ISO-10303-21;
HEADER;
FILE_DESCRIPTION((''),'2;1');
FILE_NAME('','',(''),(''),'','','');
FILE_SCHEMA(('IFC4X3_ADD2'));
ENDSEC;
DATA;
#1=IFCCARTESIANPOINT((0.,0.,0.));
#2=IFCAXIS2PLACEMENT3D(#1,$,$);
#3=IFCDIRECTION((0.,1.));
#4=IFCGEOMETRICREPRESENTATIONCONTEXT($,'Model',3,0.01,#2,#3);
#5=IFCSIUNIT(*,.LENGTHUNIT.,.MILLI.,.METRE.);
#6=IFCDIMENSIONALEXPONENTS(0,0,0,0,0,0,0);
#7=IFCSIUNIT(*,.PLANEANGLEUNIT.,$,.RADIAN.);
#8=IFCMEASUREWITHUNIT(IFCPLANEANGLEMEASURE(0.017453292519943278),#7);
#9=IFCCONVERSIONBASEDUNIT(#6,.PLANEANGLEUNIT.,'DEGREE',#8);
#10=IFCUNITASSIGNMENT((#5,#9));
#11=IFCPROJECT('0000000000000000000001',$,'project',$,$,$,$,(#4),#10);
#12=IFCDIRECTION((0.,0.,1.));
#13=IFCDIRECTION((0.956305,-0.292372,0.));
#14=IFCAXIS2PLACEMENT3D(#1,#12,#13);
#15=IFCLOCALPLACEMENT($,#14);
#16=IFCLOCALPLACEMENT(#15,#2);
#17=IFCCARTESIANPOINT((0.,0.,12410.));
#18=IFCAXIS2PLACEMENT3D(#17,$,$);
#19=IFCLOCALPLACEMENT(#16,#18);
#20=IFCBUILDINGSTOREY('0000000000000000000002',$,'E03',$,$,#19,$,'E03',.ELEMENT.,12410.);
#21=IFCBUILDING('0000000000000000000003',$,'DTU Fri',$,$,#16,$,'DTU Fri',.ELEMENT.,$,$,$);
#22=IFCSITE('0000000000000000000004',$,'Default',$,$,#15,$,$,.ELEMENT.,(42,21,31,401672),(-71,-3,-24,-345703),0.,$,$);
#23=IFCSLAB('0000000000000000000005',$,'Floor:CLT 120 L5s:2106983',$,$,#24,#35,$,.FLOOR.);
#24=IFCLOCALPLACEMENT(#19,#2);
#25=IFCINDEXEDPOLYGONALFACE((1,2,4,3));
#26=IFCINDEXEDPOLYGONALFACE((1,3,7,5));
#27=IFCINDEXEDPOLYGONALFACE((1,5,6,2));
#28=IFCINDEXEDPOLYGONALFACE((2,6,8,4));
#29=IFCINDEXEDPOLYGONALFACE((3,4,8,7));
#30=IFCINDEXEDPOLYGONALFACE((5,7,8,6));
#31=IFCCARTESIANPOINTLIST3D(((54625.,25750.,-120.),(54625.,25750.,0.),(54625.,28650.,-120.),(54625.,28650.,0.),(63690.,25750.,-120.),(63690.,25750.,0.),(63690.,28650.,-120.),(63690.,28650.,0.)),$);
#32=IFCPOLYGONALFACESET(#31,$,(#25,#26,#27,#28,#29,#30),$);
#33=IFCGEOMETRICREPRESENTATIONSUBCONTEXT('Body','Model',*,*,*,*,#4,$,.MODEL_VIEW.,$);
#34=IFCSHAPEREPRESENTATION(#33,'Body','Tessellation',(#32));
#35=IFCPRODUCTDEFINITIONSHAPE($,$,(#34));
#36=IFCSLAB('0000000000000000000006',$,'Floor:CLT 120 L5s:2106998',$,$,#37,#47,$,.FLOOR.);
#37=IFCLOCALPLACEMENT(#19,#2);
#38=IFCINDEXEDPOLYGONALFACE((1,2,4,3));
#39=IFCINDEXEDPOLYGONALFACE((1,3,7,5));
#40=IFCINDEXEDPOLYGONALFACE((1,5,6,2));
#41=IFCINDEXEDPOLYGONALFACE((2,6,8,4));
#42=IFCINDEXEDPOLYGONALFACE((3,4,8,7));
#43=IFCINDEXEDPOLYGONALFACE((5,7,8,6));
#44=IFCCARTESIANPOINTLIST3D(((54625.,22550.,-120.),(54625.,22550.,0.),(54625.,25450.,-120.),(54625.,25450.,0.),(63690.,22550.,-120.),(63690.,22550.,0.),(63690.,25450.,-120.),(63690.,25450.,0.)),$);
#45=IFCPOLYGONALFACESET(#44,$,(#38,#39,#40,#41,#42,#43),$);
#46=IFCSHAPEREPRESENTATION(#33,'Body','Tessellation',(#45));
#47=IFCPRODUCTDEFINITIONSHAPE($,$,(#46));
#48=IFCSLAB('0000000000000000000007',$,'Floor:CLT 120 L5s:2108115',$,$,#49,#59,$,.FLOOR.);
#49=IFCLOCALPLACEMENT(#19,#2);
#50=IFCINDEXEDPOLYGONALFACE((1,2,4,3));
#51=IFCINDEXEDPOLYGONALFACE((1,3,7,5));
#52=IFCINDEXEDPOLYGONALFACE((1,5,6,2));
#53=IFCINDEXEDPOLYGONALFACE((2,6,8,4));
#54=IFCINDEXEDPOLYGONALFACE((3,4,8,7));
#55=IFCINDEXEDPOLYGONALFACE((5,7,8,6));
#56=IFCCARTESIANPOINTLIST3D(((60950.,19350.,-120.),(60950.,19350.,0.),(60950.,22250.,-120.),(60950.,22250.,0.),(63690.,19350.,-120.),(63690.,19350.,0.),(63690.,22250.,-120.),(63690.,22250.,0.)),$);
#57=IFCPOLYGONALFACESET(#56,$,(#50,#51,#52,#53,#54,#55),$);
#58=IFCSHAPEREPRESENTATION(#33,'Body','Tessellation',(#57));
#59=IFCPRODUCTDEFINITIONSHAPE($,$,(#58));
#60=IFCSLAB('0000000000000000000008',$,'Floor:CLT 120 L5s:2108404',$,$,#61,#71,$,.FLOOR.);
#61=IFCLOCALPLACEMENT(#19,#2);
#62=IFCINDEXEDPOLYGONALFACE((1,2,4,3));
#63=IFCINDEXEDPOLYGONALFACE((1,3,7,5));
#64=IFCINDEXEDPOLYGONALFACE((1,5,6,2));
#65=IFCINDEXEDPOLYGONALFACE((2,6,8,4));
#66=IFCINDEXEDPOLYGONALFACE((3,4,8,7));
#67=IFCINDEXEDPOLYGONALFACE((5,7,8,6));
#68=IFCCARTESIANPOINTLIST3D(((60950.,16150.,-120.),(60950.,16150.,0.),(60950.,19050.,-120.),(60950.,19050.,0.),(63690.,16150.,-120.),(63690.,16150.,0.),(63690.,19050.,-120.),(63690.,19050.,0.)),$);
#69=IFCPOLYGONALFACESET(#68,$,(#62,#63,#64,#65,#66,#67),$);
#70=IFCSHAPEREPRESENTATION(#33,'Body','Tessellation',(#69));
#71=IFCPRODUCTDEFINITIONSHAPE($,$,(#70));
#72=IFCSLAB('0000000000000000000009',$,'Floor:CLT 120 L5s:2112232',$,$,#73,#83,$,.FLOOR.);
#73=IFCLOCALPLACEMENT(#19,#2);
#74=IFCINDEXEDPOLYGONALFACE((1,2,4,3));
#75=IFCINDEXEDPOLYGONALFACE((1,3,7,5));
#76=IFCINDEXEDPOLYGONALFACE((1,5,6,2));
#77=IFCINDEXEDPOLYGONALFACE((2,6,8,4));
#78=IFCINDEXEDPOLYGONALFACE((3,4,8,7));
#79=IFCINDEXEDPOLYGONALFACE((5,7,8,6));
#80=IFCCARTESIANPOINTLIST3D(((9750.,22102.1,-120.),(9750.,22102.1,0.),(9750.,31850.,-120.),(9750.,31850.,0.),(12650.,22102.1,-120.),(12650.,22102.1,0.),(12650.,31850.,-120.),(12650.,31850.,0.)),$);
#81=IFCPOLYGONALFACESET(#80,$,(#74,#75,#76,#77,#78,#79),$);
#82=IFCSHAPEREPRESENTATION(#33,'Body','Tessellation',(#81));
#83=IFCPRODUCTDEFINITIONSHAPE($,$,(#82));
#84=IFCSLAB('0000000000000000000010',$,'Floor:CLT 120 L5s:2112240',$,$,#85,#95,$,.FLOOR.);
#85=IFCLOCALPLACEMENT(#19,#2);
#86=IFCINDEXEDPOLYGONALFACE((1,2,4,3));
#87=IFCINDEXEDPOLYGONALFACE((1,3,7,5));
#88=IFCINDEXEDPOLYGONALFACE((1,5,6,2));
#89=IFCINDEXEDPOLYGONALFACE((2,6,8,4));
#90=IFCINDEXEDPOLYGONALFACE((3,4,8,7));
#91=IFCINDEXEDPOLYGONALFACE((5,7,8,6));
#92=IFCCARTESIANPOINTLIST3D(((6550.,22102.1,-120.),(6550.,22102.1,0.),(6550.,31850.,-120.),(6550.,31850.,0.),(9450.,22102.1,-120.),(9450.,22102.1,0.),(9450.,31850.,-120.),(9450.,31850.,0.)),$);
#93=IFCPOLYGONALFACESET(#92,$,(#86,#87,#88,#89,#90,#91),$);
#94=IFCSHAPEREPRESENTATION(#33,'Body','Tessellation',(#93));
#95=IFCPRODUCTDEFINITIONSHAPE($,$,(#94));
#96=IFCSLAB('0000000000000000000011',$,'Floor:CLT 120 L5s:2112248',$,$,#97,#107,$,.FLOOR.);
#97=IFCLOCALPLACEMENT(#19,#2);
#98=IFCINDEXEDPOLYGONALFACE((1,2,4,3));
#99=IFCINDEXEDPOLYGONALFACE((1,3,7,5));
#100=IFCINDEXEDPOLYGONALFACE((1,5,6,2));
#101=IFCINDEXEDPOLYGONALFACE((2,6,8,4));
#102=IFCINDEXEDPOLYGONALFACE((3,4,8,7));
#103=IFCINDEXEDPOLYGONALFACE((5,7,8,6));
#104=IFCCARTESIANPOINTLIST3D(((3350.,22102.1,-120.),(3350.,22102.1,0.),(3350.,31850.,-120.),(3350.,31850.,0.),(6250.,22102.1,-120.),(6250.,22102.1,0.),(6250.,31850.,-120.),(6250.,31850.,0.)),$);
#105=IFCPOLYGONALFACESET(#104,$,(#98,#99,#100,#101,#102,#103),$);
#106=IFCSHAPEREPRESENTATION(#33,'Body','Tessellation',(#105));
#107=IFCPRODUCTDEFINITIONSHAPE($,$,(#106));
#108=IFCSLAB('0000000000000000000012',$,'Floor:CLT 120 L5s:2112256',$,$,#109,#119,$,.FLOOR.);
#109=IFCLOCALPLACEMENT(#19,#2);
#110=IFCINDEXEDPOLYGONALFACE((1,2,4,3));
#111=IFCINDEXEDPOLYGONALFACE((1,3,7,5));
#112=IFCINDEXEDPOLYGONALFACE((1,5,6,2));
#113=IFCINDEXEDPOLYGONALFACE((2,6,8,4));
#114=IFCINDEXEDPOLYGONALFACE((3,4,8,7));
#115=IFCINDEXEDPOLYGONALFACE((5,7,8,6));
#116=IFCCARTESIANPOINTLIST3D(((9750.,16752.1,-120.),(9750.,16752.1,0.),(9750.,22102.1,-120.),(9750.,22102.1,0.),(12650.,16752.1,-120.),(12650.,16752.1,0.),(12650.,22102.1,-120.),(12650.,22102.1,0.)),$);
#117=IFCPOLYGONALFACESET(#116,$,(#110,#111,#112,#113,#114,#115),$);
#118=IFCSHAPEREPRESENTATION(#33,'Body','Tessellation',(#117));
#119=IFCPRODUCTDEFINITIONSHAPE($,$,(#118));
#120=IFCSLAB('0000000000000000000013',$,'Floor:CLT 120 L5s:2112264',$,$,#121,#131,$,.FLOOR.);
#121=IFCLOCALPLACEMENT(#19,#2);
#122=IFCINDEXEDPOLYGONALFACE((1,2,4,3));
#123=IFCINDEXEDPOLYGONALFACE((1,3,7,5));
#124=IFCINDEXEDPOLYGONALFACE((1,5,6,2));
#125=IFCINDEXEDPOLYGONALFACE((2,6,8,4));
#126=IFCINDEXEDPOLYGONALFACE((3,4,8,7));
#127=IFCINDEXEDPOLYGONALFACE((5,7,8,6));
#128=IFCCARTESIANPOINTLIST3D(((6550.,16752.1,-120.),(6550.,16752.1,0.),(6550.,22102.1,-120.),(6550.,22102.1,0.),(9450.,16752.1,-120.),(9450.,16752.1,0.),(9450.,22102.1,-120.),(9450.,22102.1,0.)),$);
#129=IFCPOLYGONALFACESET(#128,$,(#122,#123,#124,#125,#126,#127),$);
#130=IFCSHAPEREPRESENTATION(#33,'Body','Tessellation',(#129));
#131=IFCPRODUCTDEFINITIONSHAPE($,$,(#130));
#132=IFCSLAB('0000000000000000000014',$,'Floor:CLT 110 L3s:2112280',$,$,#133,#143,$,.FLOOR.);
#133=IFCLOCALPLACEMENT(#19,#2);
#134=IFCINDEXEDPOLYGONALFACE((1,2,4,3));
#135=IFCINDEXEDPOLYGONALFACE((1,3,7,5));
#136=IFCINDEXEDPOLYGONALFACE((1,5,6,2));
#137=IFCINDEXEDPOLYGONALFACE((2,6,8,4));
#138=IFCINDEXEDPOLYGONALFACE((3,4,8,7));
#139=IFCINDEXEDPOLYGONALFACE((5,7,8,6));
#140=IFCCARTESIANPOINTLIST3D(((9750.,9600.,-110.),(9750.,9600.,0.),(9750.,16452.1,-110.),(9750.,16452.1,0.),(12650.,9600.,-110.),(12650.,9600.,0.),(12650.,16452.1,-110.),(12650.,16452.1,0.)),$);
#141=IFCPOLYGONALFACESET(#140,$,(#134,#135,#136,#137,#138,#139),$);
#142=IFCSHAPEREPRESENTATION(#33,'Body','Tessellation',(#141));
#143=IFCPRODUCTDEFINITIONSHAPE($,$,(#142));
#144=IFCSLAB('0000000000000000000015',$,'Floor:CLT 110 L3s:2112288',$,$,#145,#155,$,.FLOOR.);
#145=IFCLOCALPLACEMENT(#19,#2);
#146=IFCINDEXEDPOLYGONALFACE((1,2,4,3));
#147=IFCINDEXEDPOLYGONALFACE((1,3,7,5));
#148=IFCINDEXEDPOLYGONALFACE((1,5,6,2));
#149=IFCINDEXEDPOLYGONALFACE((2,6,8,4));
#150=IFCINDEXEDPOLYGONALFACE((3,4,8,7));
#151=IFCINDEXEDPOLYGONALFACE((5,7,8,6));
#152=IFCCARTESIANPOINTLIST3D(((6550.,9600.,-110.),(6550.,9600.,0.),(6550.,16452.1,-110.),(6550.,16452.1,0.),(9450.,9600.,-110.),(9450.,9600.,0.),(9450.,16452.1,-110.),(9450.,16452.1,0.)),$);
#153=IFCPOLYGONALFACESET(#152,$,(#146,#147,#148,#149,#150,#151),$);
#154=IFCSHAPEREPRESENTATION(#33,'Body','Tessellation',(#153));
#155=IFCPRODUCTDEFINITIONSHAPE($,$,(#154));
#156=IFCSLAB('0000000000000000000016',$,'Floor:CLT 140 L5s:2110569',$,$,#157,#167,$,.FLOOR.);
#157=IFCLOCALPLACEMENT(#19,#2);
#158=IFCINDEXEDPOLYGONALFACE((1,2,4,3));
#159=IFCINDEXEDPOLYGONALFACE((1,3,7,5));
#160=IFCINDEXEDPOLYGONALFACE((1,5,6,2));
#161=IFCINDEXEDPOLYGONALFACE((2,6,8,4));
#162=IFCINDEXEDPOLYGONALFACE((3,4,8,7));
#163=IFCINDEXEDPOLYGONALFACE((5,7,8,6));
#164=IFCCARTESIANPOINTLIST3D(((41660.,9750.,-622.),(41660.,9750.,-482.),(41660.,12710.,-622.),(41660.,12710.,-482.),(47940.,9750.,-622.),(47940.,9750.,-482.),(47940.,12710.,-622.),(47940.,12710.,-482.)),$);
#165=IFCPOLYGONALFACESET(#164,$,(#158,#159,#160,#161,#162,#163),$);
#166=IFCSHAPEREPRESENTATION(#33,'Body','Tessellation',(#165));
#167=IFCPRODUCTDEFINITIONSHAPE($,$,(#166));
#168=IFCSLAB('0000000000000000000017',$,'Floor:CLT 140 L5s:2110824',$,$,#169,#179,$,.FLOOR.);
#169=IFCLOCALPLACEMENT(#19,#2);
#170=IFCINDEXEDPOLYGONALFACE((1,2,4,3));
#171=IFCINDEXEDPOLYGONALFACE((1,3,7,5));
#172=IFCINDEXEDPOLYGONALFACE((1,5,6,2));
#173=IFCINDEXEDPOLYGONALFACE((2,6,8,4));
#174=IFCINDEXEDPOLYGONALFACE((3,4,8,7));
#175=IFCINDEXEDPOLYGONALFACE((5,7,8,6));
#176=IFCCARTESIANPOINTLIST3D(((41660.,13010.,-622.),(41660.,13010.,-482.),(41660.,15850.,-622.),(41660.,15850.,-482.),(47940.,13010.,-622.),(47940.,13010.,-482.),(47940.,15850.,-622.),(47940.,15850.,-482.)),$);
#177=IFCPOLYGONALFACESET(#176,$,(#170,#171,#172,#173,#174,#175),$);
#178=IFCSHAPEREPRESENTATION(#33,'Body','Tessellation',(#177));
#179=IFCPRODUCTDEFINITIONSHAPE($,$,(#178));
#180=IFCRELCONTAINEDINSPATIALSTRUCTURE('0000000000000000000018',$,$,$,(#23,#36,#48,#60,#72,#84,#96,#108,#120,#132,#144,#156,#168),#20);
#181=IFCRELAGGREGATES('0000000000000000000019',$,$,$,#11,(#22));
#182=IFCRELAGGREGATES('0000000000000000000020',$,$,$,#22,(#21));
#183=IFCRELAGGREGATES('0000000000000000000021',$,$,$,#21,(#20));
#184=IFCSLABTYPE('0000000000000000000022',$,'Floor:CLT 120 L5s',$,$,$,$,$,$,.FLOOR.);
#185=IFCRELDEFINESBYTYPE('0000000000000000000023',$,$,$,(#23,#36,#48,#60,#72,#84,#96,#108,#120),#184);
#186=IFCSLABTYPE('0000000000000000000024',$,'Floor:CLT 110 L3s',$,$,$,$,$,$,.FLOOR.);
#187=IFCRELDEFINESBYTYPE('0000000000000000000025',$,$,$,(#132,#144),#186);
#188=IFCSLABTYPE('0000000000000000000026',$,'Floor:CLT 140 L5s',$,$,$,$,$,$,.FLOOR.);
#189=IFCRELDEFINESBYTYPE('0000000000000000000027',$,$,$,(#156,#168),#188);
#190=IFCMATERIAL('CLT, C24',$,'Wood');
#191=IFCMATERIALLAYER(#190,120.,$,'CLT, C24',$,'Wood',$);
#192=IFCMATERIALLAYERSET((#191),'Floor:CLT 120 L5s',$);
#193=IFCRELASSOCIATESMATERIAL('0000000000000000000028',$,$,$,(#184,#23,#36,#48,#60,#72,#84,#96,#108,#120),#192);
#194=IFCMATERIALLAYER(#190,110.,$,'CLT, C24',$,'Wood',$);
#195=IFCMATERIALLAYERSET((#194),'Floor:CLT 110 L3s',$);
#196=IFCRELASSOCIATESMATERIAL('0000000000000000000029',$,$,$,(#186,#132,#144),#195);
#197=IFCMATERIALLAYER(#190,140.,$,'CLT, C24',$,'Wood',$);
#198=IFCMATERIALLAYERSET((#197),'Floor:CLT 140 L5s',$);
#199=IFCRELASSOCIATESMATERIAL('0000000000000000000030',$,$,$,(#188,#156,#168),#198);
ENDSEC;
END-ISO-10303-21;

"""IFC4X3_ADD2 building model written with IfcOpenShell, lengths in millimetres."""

from ifc_helpers import new_model, entity, si_unit, converted_unit, direction, frame, frame_2d, origin, origin_2d_with_axis, place, context, subcontext, project, spatial, rectangle, extrude, material, layer, layer_set, layer_usage, type_object, element, save


model = new_model("IFC4X3_ADD2")

# Units and contexts
model_context = context("Model", 3, precision=0.01, world=origin(), true_north=direction((0.0, 1.0)))
body_context = subcontext(model_context, "Body", "Model", "MODEL_VIEW")
ifc_project = project(units=[si_unit("LENGTHUNIT", "METRE", prefix="MILLI"), converted_unit("PLANEANGLEUNIT", "DEGREE", entity("IfcPlaneAngleMeasure", 0.017453292519943278), si_unit("PLANEANGLEUNIT", "RADIAN"), dimensions=[0, 0, 0, 0, 0, 0, 0])], contexts=[model_context])

# Site, building, storey
site_placement = place(None, frame((0.0, 0.0, 0.0), z_axis=(0.0, 0.0, 1.0), x_axis=(0.956305, -0.292372, 0.0)))
site = spatial("IfcSite", under=ifc_project, at=site_placement, Name="Default", CompositionType="ELEMENT", RefLatitude=(42, 21, 31, 401672), RefLongitude=(-71, -3, -24, -345703), RefElevation=0.0)
building_placement = place(site_placement, origin())
building = spatial("IfcBuilding", under=site, at=building_placement, Name="DTU Fri", LongName="DTU Fri", CompositionType="ELEMENT")
storey_placement = place(building_placement, frame((0.0, 0.0, 12410.0)))
storey = spatial("IfcBuildingStorey", under=building, at=storey_placement, Name="E03", LongName="E03", CompositionType="ELEMENT", Elevation=12410.0)

# Slabs
ifc_material = material(Name="CLT, C24", Category="Wood")
ifc_layer_1 = layer(ifc_material, 120.0, Name="CLT, C24", Category="Wood")
ifc_layer_set_1 = layer_set([ifc_layer_1], Name="Floor:CLT 120 L5s")
ifc_layer_usage_1 = layer_usage(ifc_layer_set_1, "AXIS3", "POSITIVE", 0.0)
slab_type_1 = type_object("IfcSlabType", Name="Floor:CLT 120 L5s", PredefinedType="FLOOR", material=ifc_layer_set_1)
slab_1_placement = place(storey_placement, origin())
element("IfcSlab", 1, at=slab_1_placement, inside=storey, type_object=slab_type_1, material=ifc_layer_usage_1, Name="Floor:CLT 120 L5s:2106983", PredefinedType="FLOOR", context=body_context, shape_type="SweptSolid", body=[
    extrude(rectangle(XDim=2900.0, YDim=9065.0, at=frame_2d((0.0, 0.0), x_axis=(1.0, 0.0))), frame((59157.5, 27200.0, 0.0), z_axis=(0.0, 0.0, -1.0), x_axis=(0.0, 1.0, 0.0)), (0.0, 0.0, 1.0), 120.0),
])
ifc_layer_usage_2 = layer_usage(ifc_layer_set_1, "AXIS3", "POSITIVE", 0.0)
slab_2_placement = place(storey_placement, origin())
element("IfcSlab", 2, at=slab_2_placement, inside=storey, type_object=slab_type_1, material=ifc_layer_usage_2, Name="Floor:CLT 120 L5s:2106998", PredefinedType="FLOOR", context=body_context, shape_type="SweptSolid", body=[
    extrude(rectangle(XDim=2900.0, YDim=9065.0, at=frame_2d((0.0, 0.0), x_axis=(1.0, 0.0))), frame((59157.5, 24000.0, 0.0), z_axis=(0.0, 0.0, -1.0), x_axis=(0.0, 1.0, 0.0)), (0.0, 0.0, 1.0), 120.0),
])
ifc_layer_usage_3 = layer_usage(ifc_layer_set_1, "AXIS3", "POSITIVE", 0.0)
slab_3_placement = place(storey_placement, origin())
element("IfcSlab", 3, at=slab_3_placement, inside=storey, type_object=slab_type_1, material=ifc_layer_usage_3, Name="Floor:CLT 120 L5s:2108115", PredefinedType="FLOOR", context=body_context, shape_type="SweptSolid", body=[
    extrude(rectangle(XDim=2900.0, YDim=2740.0, at=frame_2d((0.0, 0.0), x_axis=(1.0, 0.0))), frame((62320.0, 20800.0, 0.0), z_axis=(0.0, 0.0, -1.0), x_axis=(0.0, 1.0, 0.0)), (0.0, 0.0, 1.0), 120.0),
])
ifc_layer_usage_4 = layer_usage(ifc_layer_set_1, "AXIS3", "POSITIVE", 0.0)
slab_4_placement = place(storey_placement, origin())
element("IfcSlab", 4, at=slab_4_placement, inside=storey, type_object=slab_type_1, material=ifc_layer_usage_4, Name="Floor:CLT 120 L5s:2108404", PredefinedType="FLOOR", context=body_context, shape_type="SweptSolid", body=[
    extrude(rectangle(XDim=2900.0, YDim=2740.0, at=frame_2d((0.0, 0.0), x_axis=(1.0, 0.0))), frame((62320.0, 17600.0, 0.0), z_axis=(0.0, 0.0, -1.0), x_axis=(0.0, 1.0, 0.0)), (0.0, 0.0, 1.0), 120.0),
])
ifc_layer_usage_5 = layer_usage(ifc_layer_set_1, "AXIS3", "POSITIVE", 0.0)
slab_5_placement = place(storey_placement, origin())
element("IfcSlab", 5, at=slab_5_placement, inside=storey, type_object=slab_type_1, material=ifc_layer_usage_5, Name="Floor:CLT 120 L5s:2112232", PredefinedType="FLOOR", context=body_context, shape_type="SweptSolid", body=[
    extrude(rectangle(XDim=9747.9, YDim=2900.0, at=frame_2d((0.0, 0.0), x_axis=(1.0, 0.0))), frame((11200.0, 26976.0, 0.0), z_axis=(0.0, 0.0, -1.0), x_axis=(0.0, 1.0, 0.0)), (0.0, 0.0, 1.0), 120.0),
])
ifc_layer_usage_6 = layer_usage(ifc_layer_set_1, "AXIS3", "POSITIVE", 0.0)
slab_6_placement = place(storey_placement, origin())
element("IfcSlab", 6, at=slab_6_placement, inside=storey, type_object=slab_type_1, material=ifc_layer_usage_6, Name="Floor:CLT 120 L5s:2112240", PredefinedType="FLOOR", context=body_context, shape_type="SweptSolid", body=[
    extrude(rectangle(XDim=9747.9, YDim=2900.0, at=frame_2d((0.0, 0.0), x_axis=(1.0, 0.0))), frame((8000.0, 26976.0, 0.0), z_axis=(0.0, 0.0, -1.0), x_axis=(0.0, 1.0, 0.0)), (0.0, 0.0, 1.0), 120.0),
])
ifc_layer_usage_7 = layer_usage(ifc_layer_set_1, "AXIS3", "POSITIVE", 0.0)
slab_7_placement = place(storey_placement, origin())
element("IfcSlab", 7, at=slab_7_placement, inside=storey, type_object=slab_type_1, material=ifc_layer_usage_7, Name="Floor:CLT 120 L5s:2112248", PredefinedType="FLOOR", context=body_context, shape_type="SweptSolid", body=[
    extrude(rectangle(XDim=9747.9, YDim=2900.0, at=frame_2d((0.0, 0.0), x_axis=(1.0, 0.0))), frame((4800.0, 26976.0, 0.0), z_axis=(0.0, 0.0, -1.0), x_axis=(0.0, 1.0, 0.0)), (0.0, 0.0, 1.0), 120.0),
])
ifc_layer_usage_8 = layer_usage(ifc_layer_set_1, "AXIS3", "POSITIVE", 0.0)
slab_8_placement = place(storey_placement, origin())
element("IfcSlab", 8, at=slab_8_placement, inside=storey, type_object=slab_type_1, material=ifc_layer_usage_8, Name="Floor:CLT 120 L5s:2112256", PredefinedType="FLOOR", context=body_context, shape_type="SweptSolid", body=[
    extrude(rectangle(XDim=5350.0, YDim=2900.0, at=frame_2d((0.0, 0.0), x_axis=(1.0, 0.0))), frame((11200.0, 19427.1, 0.0), z_axis=(0.0, 0.0, -1.0), x_axis=(0.0, 1.0, 0.0)), (0.0, 0.0, 1.0), 120.0),
])
ifc_layer_usage_9 = layer_usage(ifc_layer_set_1, "AXIS3", "POSITIVE", 0.0)
slab_9_placement = place(storey_placement, origin())
element("IfcSlab", 9, at=slab_9_placement, inside=storey, type_object=slab_type_1, material=ifc_layer_usage_9, Name="Floor:CLT 120 L5s:2112264", PredefinedType="FLOOR", context=body_context, shape_type="SweptSolid", body=[
    extrude(rectangle(XDim=5350.0, YDim=2900.0, at=frame_2d((0.0, 0.0), x_axis=(1.0, 0.0))), frame((8000.0, 19427.1, 0.0), z_axis=(0.0, 0.0, -1.0), x_axis=(0.0, 1.0, 0.0)), (0.0, 0.0, 1.0), 120.0),
])
ifc_layer_2 = layer(ifc_material, 110.0, Name="CLT, C24", Category="Wood")
ifc_layer_set_2 = layer_set([ifc_layer_2], Name="Floor:CLT 110 L3s")
ifc_layer_usage_10 = layer_usage(ifc_layer_set_2, "AXIS3", "POSITIVE", 0.0)
slab_type_2 = type_object("IfcSlabType", Name="Floor:CLT 110 L3s", PredefinedType="FLOOR", material=ifc_layer_set_2)
slab_10_placement = place(storey_placement, origin())
element("IfcSlab", 10, at=slab_10_placement, inside=storey, type_object=slab_type_2, material=ifc_layer_usage_10, Name="Floor:CLT 110 L3s:2112280", PredefinedType="FLOOR", context=body_context, shape_type="SweptSolid", body=[
    extrude(rectangle(XDim=6852.1, YDim=2900.0, at=frame_2d((0.0, 0.0), x_axis=(1.0, 0.0))), frame((11200.0, 13026.0, 0.0), z_axis=(0.0, 0.0, -1.0), x_axis=(0.0, 1.0, 0.0)), (0.0, 0.0, 1.0), 110.0),
])
ifc_layer_usage_11 = layer_usage(ifc_layer_set_2, "AXIS3", "POSITIVE", 0.0)
slab_11_placement = place(storey_placement, origin())
element("IfcSlab", 11, at=slab_11_placement, inside=storey, type_object=slab_type_2, material=ifc_layer_usage_11, Name="Floor:CLT 110 L3s:2112288", PredefinedType="FLOOR", context=body_context, shape_type="SweptSolid", body=[
    extrude(rectangle(XDim=6852.1, YDim=2900.0, at=frame_2d((0.0, 0.0), x_axis=(1.0, 0.0))), frame((8000.0, 13026.0, 0.0), z_axis=(0.0, 0.0, -1.0), x_axis=(0.0, 1.0, 0.0)), (0.0, 0.0, 1.0), 110.0),
])
ifc_layer_3 = layer(ifc_material, 140.0, Name="CLT, C24", Category="Wood")
ifc_layer_set_3 = layer_set([ifc_layer_3], Name="Floor:CLT 140 L5s")
ifc_layer_usage_12 = layer_usage(ifc_layer_set_3, "AXIS3", "POSITIVE", 0.0)
slab_type_3 = type_object("IfcSlabType", Name="Floor:CLT 140 L5s", PredefinedType="FLOOR", material=ifc_layer_set_3)
slab_12_placement = place(storey_placement, origin())
element("IfcSlab", 12, at=slab_12_placement, inside=storey, type_object=slab_type_3, material=ifc_layer_usage_12, Name="Floor:CLT 140 L5s:2110569", PredefinedType="FLOOR", context=body_context, shape_type="SweptSolid", body=[
    extrude(rectangle(XDim=2960.0, YDim=6280.0, at=frame_2d((0.0, 0.0), x_axis=(1.0, 0.0))), frame((44800.0, 11230.0, -482.0), z_axis=(0.0, 0.0, -1.0), x_axis=(0.0, 1.0, 0.0)), (0.0, 0.0, 1.0), 140.0),
])
ifc_layer_usage_13 = layer_usage(ifc_layer_set_3, "AXIS3", "POSITIVE", 0.0)
slab_13_placement = place(storey_placement, origin())
element("IfcSlab", 13, at=slab_13_placement, inside=storey, type_object=slab_type_3, material=ifc_layer_usage_13, Name="Floor:CLT 140 L5s:2110824", PredefinedType="FLOOR", context=body_context, shape_type="SweptSolid", body=[
    extrude(rectangle(XDim=2840.0, YDim=6280.0, at=origin_2d_with_axis()), frame((44800.0, 14430.0, -482.0), z_axis=(0.0, 0.0, -1.0), x_axis=(0.0, 1.0, 0.0)), (0.0, 0.0, 1.0), 140.0),
])

save(model, "model.ifc")
